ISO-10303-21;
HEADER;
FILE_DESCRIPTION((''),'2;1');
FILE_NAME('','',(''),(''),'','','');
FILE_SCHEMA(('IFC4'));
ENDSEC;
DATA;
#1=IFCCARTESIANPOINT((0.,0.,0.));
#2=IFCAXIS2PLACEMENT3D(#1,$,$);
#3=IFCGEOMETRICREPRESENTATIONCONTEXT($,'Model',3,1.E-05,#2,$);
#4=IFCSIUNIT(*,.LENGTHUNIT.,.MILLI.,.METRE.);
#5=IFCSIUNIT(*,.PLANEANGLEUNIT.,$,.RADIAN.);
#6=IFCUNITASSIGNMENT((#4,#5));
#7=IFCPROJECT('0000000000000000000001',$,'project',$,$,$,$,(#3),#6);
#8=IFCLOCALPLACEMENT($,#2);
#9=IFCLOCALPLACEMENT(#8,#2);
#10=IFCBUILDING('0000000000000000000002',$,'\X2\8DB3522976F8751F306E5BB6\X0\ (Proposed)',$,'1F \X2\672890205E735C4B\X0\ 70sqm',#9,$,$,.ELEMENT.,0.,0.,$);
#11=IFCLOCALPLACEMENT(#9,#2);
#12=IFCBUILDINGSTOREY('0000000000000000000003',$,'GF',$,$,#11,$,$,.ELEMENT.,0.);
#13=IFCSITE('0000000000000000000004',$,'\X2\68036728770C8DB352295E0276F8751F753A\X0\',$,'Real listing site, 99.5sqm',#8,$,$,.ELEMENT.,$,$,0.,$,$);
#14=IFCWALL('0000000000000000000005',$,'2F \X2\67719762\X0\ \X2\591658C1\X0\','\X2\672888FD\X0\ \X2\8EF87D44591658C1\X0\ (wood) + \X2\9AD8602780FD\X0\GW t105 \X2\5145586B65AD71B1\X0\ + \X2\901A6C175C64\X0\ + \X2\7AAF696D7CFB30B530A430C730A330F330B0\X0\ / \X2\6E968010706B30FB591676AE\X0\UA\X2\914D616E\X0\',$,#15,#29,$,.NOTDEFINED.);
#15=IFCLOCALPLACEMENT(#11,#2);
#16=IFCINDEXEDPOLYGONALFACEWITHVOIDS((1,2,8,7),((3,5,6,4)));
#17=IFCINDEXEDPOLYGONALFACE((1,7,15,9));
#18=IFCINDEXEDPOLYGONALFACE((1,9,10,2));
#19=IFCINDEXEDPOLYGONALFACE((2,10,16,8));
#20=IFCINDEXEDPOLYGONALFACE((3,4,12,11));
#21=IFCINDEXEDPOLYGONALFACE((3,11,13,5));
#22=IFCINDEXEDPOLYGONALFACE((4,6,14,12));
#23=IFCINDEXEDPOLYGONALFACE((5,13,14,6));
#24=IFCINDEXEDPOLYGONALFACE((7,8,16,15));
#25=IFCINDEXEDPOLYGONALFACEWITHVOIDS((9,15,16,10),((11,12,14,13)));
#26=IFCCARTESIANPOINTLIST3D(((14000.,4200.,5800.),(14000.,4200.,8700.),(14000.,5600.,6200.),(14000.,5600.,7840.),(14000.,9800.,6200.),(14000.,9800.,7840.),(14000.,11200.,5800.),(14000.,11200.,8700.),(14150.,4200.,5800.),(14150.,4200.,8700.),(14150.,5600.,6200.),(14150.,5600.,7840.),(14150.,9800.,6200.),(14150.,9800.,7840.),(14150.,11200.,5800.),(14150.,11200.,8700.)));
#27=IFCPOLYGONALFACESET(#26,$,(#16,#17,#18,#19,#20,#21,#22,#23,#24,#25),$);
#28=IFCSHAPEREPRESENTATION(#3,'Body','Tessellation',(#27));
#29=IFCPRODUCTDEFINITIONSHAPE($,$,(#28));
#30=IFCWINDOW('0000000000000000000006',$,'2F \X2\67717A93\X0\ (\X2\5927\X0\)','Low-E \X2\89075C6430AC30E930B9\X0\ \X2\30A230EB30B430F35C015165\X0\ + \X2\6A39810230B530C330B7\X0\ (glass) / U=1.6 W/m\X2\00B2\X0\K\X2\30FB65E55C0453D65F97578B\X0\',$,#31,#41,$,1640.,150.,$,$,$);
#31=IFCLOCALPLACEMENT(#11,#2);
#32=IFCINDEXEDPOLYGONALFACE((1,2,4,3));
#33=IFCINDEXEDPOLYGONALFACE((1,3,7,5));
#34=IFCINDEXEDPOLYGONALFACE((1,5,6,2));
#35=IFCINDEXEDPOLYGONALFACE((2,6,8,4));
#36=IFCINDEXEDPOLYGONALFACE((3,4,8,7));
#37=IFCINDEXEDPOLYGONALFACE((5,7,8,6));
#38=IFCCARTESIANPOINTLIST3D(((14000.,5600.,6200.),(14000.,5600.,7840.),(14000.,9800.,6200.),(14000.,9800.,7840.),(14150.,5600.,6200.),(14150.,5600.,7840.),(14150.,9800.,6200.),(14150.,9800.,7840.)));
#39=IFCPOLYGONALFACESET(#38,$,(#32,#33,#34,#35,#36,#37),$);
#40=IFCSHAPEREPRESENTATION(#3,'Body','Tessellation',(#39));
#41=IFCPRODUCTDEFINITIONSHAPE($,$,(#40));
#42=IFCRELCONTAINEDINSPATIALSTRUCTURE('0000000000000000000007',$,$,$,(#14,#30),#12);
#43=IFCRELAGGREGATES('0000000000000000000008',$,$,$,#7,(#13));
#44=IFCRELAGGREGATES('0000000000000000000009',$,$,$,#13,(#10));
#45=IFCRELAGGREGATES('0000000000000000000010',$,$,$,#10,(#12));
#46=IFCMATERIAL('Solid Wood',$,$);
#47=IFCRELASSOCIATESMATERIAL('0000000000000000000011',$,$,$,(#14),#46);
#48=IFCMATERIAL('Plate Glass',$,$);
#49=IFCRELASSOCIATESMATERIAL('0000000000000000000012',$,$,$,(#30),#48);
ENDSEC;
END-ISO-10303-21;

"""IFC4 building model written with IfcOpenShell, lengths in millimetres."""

from ifc_helpers import new_model, si_unit, frame, frame_2d, origin, place, context, project, spatial, rectangle, extrude, material, element, fill, save


model = new_model("IFC4")

# Units and contexts
model_context = context("Model", 3, precision=1e-05, world=origin())
ifc_project = project(units=[si_unit("LENGTHUNIT", "METRE", prefix="MILLI"), si_unit("PLANEANGLEUNIT", "RADIAN")], contexts=[model_context])

# Site, building, storey
site_placement = place(None, origin())
site = spatial("IfcSite", under=ifc_project, at=site_placement, Name="栃木県足利市相生町", ObjectType="Real listing site, 99.5sqm", CompositionType="ELEMENT", RefElevation=0.0)
building_placement = place(site_placement, origin())
building = spatial("IfcBuilding", under=site, at=building_placement, Name="足利相生の家 (Proposed)", ObjectType="1F 木造平屋 70sqm", CompositionType="ELEMENT", ElevationOfRefHeight=0.0, ElevationOfTerrain=0.0)
storey_placement = place(building_placement, origin())
storey = spatial("IfcBuildingStorey", under=building, at=storey_placement, Name="GF", CompositionType="ELEMENT", Elevation=0.0)

# Shared definitions
ifc_material_1 = material(Name="Solid Wood")

# Shared definitions
ifc_material_2 = material(Name="Plate Glass")

# Wall, opening, window
wall_1_placement = place(storey_placement, frame((7000.0, 2100.0, 2900.0)))
wall_1 = element("IfcWall", 1, at=wall_1_placement, inside=storey, material=ifc_material_1, Name="2F 東面 外壁", Description="木製 軸組外壁 (wood) + 高性能GW t105 充填断熱 + 通気層 + 窯業系サイディング / 準耐火・外皮UA配慮", PredefinedType="NOTDEFINED", context=model_context, shape_type="SweptSolid", body=[
    extrude(rectangle(XDim=150.0, YDim=7000.0, at=frame_2d((75.0, 3500.0))), frame((7000.0, 2100.0, 2900.0)), (0.0, 0.0, 1.0), 2900.0),
])
opening_1_placement = place(storey_placement, frame((7000.0, 2800.0, 3100.0)))
opening_1 = element("IfcOpeningElement", 2, at=opening_1_placement, cuts=wall_1, PredefinedType="NOTDEFINED", context=model_context, shape_type="SweptSolid", body=[
    extrude(rectangle(XDim=150.0, YDim=4200.0, at=frame_2d((75.0, 2100.0))), frame((7000.0, 2800.0, 3100.0)), (0.0, 0.0, 1.0), 1640.0),
])
window_1_placement = place(storey_placement, frame((7000.0, 2800.0, 3100.0)))
window_1 = element("IfcWindow", 3, at=window_1_placement, inside=storey, material=ifc_material_2, Name="2F 東窓 (大)", Description="Low-E 複層ガラス アルゴン封入 + 樹脂サッシ (glass) / U=1.6 W/m²K・日射取得型", OverallHeight=1640.0, OverallWidth=150.0, context=model_context, shape_type="SweptSolid", body=[
    extrude(rectangle(XDim=150.0, YDim=4200.0, at=frame_2d((75.0, 2100.0))), frame((7000.0, 2800.0, 3100.0)), (0.0, 0.0, 1.0), 1640.0),
])
fill(opening_1, window_1)

save(model, "model.ifc")
